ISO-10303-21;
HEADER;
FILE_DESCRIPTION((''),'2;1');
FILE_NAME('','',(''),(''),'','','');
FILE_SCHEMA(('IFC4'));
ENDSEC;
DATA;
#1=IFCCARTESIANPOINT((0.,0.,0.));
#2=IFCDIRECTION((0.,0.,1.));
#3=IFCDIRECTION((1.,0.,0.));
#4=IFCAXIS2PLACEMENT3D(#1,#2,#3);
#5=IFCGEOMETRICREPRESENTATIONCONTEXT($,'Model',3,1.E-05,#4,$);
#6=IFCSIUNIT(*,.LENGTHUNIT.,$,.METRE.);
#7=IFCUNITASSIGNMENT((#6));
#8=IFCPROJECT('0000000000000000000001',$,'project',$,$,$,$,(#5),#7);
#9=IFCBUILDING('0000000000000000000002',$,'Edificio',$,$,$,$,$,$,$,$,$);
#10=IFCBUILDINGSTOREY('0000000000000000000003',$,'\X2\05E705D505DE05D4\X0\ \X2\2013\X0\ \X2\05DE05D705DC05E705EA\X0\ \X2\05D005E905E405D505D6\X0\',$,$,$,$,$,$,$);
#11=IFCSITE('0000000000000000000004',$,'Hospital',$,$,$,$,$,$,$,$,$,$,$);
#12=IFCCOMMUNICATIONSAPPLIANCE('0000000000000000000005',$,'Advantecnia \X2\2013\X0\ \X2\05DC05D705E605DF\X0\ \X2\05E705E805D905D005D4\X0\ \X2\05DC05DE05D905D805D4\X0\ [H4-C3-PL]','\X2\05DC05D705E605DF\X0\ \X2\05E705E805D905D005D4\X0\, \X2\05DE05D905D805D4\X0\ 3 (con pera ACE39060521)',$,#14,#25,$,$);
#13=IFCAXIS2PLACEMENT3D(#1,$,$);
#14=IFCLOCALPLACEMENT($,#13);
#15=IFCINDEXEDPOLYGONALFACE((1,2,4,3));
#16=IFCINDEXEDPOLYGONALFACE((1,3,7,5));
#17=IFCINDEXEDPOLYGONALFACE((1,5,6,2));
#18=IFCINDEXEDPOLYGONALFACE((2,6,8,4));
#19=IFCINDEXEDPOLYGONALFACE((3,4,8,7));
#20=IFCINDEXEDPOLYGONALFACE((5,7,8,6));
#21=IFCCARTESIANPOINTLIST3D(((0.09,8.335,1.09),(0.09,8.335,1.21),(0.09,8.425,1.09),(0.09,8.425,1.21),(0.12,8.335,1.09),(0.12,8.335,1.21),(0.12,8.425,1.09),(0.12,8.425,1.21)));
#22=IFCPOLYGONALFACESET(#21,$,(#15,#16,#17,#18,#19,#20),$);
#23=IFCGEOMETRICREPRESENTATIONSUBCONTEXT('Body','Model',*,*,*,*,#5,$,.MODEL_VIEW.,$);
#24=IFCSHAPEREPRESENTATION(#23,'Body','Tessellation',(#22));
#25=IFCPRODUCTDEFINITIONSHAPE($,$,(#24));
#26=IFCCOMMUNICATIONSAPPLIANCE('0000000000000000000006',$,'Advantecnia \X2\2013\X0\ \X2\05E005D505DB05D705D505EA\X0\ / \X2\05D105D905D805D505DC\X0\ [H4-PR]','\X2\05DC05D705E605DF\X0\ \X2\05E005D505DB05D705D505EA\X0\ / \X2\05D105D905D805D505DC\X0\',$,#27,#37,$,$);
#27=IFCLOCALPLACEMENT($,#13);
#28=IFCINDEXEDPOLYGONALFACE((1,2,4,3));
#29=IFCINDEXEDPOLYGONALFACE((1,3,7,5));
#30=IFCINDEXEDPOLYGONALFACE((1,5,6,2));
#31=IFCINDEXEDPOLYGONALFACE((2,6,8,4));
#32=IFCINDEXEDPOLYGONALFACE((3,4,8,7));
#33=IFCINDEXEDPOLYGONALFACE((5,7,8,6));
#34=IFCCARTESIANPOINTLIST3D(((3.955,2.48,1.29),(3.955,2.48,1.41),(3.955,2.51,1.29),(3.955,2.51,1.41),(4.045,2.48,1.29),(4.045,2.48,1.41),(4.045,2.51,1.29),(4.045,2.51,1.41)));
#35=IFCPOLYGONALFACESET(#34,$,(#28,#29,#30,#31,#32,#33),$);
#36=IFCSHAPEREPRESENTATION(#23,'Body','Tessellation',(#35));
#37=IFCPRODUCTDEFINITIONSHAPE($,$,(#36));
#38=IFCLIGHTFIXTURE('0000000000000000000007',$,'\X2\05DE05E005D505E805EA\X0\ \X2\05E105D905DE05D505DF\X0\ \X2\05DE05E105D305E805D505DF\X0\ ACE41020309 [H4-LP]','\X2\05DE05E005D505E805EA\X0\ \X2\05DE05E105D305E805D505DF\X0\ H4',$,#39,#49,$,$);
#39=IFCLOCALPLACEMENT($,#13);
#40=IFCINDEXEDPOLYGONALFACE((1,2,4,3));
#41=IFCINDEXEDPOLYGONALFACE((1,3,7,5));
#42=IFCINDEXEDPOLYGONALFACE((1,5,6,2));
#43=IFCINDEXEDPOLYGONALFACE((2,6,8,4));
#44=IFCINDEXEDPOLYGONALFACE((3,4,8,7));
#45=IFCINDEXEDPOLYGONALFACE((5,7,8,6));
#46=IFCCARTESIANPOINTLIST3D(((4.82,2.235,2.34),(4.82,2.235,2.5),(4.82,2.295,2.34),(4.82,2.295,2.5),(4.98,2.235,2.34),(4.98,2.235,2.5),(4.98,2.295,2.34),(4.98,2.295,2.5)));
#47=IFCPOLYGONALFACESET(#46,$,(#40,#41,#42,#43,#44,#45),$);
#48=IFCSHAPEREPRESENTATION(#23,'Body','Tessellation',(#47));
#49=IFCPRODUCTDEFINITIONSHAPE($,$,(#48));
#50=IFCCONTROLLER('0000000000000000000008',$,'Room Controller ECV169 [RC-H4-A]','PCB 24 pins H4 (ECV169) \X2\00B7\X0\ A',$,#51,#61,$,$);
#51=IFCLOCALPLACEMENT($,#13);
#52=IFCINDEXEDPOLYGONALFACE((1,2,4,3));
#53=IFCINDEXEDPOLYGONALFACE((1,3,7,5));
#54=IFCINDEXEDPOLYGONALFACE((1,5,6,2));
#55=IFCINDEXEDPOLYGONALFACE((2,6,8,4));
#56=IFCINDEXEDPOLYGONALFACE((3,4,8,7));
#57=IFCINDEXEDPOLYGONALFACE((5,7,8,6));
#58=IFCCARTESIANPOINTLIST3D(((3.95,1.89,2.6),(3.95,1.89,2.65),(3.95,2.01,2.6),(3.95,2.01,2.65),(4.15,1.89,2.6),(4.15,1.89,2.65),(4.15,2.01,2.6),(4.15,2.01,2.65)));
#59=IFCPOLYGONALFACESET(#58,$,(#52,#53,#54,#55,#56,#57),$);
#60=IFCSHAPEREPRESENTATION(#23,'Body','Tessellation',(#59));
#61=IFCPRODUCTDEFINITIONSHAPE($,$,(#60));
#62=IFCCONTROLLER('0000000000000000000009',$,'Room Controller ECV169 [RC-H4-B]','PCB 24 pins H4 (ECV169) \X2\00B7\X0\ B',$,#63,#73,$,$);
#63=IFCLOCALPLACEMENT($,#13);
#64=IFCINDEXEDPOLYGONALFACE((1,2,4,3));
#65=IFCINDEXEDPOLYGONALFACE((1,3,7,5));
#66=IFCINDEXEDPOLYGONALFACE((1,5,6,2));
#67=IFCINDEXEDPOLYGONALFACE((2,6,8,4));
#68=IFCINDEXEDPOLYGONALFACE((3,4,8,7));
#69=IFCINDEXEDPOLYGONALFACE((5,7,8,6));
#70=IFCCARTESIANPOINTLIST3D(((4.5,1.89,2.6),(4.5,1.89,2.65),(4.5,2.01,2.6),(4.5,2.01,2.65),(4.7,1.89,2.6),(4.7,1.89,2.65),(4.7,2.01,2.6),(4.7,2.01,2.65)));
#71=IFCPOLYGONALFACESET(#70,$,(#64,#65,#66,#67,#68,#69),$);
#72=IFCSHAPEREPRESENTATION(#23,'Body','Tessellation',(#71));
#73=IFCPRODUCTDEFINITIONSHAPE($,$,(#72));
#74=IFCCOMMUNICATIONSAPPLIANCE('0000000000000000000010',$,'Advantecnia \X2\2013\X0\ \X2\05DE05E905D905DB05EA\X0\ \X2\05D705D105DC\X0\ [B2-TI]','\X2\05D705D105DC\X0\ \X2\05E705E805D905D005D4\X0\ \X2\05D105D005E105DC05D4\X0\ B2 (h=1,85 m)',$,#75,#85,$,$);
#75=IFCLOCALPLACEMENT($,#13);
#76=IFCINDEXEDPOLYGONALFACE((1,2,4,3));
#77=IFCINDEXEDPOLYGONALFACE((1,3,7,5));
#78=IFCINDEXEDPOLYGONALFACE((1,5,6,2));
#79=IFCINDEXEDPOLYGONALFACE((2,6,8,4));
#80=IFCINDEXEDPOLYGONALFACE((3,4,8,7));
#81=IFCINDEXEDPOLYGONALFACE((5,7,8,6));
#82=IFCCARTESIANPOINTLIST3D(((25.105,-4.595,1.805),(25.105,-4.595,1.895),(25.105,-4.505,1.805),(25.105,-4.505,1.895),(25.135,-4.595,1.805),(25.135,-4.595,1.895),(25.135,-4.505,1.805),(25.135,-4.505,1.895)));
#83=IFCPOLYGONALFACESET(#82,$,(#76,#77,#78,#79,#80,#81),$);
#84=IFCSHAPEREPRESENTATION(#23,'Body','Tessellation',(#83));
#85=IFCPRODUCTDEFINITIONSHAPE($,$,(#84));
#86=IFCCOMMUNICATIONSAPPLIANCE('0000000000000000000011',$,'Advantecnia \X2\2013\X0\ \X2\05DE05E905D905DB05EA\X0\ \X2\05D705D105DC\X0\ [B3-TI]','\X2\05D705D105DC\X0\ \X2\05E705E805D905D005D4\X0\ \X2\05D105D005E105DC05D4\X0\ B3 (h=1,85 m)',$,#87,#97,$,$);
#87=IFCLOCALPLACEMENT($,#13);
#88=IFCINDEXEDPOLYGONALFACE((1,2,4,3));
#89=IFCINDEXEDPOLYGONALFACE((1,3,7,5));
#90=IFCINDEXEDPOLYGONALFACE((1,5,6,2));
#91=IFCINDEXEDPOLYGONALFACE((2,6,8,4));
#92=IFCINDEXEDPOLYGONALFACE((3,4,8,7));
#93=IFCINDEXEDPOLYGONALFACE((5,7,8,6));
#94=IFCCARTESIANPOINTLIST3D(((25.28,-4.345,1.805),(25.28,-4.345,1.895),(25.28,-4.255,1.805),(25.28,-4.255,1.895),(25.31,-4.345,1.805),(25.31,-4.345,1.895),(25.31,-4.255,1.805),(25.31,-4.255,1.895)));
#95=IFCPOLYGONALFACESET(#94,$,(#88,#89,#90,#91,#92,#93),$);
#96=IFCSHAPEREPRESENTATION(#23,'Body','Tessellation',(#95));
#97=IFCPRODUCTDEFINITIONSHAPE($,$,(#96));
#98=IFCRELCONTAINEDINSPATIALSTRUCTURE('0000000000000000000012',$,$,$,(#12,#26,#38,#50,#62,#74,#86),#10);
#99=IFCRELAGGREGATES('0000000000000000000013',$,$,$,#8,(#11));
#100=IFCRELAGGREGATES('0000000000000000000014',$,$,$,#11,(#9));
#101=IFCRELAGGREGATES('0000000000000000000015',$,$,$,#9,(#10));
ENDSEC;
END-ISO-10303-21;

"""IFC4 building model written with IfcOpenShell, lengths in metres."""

from ifc_helpers import new_model, si_unit, frame, origin_with_axes, context, subcontext, project, spatial, line, indexed_curve, outline, extrude, element, save


model = new_model("IFC4")

# Units and contexts
model_context = context("Model", 3, precision=1e-05, world=origin_with_axes())
body_context = subcontext(model_context, "Body", "Model", "MODEL_VIEW")
ifc_project = project(units=[si_unit("LENGTHUNIT", "METRE")], contexts=[model_context])

# Site, building, storey
site = spatial("IfcSite", under=ifc_project, Name="Hospital")
building = spatial("IfcBuilding", under=site, Name="Edificio")
storey = spatial("IfcBuildingStorey", under=building, Name="קומה – מחלקת אשפוז")

# Communications appliances
element("IfcCommunicationsAppliance", 1, inside=storey, Name="Advantecnia – לחצן קריאה למיטה [H4-C3-PL]", Description="לחצן קריאה, מיטה 3 (con pera ACE39060521)", context=body_context, shape_type="SweptSolid", body=[
    extrude(outline(indexed_curve([(0.0, 0.0), (0.03, 0.0), (0.03, 0.09), (0.0, 0.09)], segments=[line(1, 2, 3, 4, 1)])), frame((0.09, 8.335, 1.09), z_axis=(0.0, 0.0, 1.0), x_axis=(1.0, 0.0, 0.0)), (0.0, 0.0, 1.0), 0.12),
])
element("IfcCommunicationsAppliance", 2, inside=storey, Name="Advantecnia – נוכחות / ביטול [H4-PR]", Description="לחצן נוכחות / ביטול", context=body_context, shape_type="SweptSolid", body=[
    extrude(outline(indexed_curve([(0.0, 0.0), (0.09, 0.0), (0.09, 0.03), (0.0, 0.03)], segments=[line(1, 2, 3, 4, 1)])), frame((3.955, 2.48, 1.29), z_axis=(0.0, 0.0, 1.0), x_axis=(1.0, 0.0, 0.0)), (0.0, 0.0, 1.0), 0.12),
])

# Light fixture
element("IfcLightFixture", 3, inside=storey, Name="מנורת סימון מסדרון ACE41020309 [H4-LP]", Description="מנורת מסדרון H4", context=body_context, shape_type="SweptSolid", body=[
    extrude(outline(indexed_curve([(0.0, 0.0), (0.16, 0.0), (0.16, 0.06), (0.0, 0.06)], segments=[line(1, 2, 3, 4, 1)])), frame((4.82, 2.235, 2.34), z_axis=(0.0, 0.0, 1.0), x_axis=(1.0, 0.0, 0.0)), (0.0, 0.0, 1.0), 0.16),
])

# Controllers
element("IfcController", 4, inside=storey, Name="Room Controller ECV169 [RC-H4-A]", Description="PCB 24 pins H4 (ECV169) · A", context=body_context, shape_type="SweptSolid", body=[
    extrude(outline(indexed_curve([(0.0, 0.0), (0.2, 0.0), (0.2, 0.12), (0.0, 0.12)], segments=[line(1, 2, 3, 4, 1)])), frame((3.95, 1.89, 2.6), z_axis=(0.0, 0.0, 1.0), x_axis=(1.0, 0.0, 0.0)), (0.0, 0.0, 1.0), 0.05),
])
element("IfcController", 5, inside=storey, Name="Room Controller ECV169 [RC-H4-B]", Description="PCB 24 pins H4 (ECV169) · B", context=body_context, shape_type="SweptSolid", body=[
    extrude(outline(indexed_curve([(0.0, 0.0), (0.2, 0.0), (0.2, 0.12), (0.0, 0.12)], segments=[line(1, 2, 3, 4, 1)])), frame((4.5, 1.89, 2.6), z_axis=(0.0, 0.0, 1.0), x_axis=(1.0, 0.0, 0.0)), (0.0, 0.0, 1.0), 0.05),
])

# Communications appliances
element("IfcCommunicationsAppliance", 6, inside=storey, Name="Advantecnia – משיכת חבל [B2-TI]", Description="חבל קריאה באסלה B2 (h=1,85 m)", context=body_context, shape_type="SweptSolid", body=[
    extrude(outline(indexed_curve([(0.0, 0.0), (0.03, 0.0), (0.03, 0.09), (0.0, 0.09)], segments=[line(1, 2, 3, 4, 1)])), frame((25.105, -4.595, 1.805), z_axis=(0.0, 0.0, 1.0), x_axis=(1.0, 0.0, 0.0)), (0.0, 0.0, 1.0), 0.09),
])
element("IfcCommunicationsAppliance", 7, inside=storey, Name="Advantecnia – משיכת חבל [B3-TI]", Description="חבל קריאה באסלה B3 (h=1,85 m)", context=body_context, shape_type="SweptSolid", body=[
    extrude(outline(indexed_curve([(0.0, 0.0), (0.03, 0.0), (0.03, 0.09), (0.0, 0.09)], segments=[line(1, 2, 3, 4, 1)])), frame((25.28, -4.345, 1.805), z_axis=(0.0, 0.0, 1.0), x_axis=(1.0, 0.0, 0.0)), (0.0, 0.0, 1.0), 0.09),
])

save(model, "model.ifc")
